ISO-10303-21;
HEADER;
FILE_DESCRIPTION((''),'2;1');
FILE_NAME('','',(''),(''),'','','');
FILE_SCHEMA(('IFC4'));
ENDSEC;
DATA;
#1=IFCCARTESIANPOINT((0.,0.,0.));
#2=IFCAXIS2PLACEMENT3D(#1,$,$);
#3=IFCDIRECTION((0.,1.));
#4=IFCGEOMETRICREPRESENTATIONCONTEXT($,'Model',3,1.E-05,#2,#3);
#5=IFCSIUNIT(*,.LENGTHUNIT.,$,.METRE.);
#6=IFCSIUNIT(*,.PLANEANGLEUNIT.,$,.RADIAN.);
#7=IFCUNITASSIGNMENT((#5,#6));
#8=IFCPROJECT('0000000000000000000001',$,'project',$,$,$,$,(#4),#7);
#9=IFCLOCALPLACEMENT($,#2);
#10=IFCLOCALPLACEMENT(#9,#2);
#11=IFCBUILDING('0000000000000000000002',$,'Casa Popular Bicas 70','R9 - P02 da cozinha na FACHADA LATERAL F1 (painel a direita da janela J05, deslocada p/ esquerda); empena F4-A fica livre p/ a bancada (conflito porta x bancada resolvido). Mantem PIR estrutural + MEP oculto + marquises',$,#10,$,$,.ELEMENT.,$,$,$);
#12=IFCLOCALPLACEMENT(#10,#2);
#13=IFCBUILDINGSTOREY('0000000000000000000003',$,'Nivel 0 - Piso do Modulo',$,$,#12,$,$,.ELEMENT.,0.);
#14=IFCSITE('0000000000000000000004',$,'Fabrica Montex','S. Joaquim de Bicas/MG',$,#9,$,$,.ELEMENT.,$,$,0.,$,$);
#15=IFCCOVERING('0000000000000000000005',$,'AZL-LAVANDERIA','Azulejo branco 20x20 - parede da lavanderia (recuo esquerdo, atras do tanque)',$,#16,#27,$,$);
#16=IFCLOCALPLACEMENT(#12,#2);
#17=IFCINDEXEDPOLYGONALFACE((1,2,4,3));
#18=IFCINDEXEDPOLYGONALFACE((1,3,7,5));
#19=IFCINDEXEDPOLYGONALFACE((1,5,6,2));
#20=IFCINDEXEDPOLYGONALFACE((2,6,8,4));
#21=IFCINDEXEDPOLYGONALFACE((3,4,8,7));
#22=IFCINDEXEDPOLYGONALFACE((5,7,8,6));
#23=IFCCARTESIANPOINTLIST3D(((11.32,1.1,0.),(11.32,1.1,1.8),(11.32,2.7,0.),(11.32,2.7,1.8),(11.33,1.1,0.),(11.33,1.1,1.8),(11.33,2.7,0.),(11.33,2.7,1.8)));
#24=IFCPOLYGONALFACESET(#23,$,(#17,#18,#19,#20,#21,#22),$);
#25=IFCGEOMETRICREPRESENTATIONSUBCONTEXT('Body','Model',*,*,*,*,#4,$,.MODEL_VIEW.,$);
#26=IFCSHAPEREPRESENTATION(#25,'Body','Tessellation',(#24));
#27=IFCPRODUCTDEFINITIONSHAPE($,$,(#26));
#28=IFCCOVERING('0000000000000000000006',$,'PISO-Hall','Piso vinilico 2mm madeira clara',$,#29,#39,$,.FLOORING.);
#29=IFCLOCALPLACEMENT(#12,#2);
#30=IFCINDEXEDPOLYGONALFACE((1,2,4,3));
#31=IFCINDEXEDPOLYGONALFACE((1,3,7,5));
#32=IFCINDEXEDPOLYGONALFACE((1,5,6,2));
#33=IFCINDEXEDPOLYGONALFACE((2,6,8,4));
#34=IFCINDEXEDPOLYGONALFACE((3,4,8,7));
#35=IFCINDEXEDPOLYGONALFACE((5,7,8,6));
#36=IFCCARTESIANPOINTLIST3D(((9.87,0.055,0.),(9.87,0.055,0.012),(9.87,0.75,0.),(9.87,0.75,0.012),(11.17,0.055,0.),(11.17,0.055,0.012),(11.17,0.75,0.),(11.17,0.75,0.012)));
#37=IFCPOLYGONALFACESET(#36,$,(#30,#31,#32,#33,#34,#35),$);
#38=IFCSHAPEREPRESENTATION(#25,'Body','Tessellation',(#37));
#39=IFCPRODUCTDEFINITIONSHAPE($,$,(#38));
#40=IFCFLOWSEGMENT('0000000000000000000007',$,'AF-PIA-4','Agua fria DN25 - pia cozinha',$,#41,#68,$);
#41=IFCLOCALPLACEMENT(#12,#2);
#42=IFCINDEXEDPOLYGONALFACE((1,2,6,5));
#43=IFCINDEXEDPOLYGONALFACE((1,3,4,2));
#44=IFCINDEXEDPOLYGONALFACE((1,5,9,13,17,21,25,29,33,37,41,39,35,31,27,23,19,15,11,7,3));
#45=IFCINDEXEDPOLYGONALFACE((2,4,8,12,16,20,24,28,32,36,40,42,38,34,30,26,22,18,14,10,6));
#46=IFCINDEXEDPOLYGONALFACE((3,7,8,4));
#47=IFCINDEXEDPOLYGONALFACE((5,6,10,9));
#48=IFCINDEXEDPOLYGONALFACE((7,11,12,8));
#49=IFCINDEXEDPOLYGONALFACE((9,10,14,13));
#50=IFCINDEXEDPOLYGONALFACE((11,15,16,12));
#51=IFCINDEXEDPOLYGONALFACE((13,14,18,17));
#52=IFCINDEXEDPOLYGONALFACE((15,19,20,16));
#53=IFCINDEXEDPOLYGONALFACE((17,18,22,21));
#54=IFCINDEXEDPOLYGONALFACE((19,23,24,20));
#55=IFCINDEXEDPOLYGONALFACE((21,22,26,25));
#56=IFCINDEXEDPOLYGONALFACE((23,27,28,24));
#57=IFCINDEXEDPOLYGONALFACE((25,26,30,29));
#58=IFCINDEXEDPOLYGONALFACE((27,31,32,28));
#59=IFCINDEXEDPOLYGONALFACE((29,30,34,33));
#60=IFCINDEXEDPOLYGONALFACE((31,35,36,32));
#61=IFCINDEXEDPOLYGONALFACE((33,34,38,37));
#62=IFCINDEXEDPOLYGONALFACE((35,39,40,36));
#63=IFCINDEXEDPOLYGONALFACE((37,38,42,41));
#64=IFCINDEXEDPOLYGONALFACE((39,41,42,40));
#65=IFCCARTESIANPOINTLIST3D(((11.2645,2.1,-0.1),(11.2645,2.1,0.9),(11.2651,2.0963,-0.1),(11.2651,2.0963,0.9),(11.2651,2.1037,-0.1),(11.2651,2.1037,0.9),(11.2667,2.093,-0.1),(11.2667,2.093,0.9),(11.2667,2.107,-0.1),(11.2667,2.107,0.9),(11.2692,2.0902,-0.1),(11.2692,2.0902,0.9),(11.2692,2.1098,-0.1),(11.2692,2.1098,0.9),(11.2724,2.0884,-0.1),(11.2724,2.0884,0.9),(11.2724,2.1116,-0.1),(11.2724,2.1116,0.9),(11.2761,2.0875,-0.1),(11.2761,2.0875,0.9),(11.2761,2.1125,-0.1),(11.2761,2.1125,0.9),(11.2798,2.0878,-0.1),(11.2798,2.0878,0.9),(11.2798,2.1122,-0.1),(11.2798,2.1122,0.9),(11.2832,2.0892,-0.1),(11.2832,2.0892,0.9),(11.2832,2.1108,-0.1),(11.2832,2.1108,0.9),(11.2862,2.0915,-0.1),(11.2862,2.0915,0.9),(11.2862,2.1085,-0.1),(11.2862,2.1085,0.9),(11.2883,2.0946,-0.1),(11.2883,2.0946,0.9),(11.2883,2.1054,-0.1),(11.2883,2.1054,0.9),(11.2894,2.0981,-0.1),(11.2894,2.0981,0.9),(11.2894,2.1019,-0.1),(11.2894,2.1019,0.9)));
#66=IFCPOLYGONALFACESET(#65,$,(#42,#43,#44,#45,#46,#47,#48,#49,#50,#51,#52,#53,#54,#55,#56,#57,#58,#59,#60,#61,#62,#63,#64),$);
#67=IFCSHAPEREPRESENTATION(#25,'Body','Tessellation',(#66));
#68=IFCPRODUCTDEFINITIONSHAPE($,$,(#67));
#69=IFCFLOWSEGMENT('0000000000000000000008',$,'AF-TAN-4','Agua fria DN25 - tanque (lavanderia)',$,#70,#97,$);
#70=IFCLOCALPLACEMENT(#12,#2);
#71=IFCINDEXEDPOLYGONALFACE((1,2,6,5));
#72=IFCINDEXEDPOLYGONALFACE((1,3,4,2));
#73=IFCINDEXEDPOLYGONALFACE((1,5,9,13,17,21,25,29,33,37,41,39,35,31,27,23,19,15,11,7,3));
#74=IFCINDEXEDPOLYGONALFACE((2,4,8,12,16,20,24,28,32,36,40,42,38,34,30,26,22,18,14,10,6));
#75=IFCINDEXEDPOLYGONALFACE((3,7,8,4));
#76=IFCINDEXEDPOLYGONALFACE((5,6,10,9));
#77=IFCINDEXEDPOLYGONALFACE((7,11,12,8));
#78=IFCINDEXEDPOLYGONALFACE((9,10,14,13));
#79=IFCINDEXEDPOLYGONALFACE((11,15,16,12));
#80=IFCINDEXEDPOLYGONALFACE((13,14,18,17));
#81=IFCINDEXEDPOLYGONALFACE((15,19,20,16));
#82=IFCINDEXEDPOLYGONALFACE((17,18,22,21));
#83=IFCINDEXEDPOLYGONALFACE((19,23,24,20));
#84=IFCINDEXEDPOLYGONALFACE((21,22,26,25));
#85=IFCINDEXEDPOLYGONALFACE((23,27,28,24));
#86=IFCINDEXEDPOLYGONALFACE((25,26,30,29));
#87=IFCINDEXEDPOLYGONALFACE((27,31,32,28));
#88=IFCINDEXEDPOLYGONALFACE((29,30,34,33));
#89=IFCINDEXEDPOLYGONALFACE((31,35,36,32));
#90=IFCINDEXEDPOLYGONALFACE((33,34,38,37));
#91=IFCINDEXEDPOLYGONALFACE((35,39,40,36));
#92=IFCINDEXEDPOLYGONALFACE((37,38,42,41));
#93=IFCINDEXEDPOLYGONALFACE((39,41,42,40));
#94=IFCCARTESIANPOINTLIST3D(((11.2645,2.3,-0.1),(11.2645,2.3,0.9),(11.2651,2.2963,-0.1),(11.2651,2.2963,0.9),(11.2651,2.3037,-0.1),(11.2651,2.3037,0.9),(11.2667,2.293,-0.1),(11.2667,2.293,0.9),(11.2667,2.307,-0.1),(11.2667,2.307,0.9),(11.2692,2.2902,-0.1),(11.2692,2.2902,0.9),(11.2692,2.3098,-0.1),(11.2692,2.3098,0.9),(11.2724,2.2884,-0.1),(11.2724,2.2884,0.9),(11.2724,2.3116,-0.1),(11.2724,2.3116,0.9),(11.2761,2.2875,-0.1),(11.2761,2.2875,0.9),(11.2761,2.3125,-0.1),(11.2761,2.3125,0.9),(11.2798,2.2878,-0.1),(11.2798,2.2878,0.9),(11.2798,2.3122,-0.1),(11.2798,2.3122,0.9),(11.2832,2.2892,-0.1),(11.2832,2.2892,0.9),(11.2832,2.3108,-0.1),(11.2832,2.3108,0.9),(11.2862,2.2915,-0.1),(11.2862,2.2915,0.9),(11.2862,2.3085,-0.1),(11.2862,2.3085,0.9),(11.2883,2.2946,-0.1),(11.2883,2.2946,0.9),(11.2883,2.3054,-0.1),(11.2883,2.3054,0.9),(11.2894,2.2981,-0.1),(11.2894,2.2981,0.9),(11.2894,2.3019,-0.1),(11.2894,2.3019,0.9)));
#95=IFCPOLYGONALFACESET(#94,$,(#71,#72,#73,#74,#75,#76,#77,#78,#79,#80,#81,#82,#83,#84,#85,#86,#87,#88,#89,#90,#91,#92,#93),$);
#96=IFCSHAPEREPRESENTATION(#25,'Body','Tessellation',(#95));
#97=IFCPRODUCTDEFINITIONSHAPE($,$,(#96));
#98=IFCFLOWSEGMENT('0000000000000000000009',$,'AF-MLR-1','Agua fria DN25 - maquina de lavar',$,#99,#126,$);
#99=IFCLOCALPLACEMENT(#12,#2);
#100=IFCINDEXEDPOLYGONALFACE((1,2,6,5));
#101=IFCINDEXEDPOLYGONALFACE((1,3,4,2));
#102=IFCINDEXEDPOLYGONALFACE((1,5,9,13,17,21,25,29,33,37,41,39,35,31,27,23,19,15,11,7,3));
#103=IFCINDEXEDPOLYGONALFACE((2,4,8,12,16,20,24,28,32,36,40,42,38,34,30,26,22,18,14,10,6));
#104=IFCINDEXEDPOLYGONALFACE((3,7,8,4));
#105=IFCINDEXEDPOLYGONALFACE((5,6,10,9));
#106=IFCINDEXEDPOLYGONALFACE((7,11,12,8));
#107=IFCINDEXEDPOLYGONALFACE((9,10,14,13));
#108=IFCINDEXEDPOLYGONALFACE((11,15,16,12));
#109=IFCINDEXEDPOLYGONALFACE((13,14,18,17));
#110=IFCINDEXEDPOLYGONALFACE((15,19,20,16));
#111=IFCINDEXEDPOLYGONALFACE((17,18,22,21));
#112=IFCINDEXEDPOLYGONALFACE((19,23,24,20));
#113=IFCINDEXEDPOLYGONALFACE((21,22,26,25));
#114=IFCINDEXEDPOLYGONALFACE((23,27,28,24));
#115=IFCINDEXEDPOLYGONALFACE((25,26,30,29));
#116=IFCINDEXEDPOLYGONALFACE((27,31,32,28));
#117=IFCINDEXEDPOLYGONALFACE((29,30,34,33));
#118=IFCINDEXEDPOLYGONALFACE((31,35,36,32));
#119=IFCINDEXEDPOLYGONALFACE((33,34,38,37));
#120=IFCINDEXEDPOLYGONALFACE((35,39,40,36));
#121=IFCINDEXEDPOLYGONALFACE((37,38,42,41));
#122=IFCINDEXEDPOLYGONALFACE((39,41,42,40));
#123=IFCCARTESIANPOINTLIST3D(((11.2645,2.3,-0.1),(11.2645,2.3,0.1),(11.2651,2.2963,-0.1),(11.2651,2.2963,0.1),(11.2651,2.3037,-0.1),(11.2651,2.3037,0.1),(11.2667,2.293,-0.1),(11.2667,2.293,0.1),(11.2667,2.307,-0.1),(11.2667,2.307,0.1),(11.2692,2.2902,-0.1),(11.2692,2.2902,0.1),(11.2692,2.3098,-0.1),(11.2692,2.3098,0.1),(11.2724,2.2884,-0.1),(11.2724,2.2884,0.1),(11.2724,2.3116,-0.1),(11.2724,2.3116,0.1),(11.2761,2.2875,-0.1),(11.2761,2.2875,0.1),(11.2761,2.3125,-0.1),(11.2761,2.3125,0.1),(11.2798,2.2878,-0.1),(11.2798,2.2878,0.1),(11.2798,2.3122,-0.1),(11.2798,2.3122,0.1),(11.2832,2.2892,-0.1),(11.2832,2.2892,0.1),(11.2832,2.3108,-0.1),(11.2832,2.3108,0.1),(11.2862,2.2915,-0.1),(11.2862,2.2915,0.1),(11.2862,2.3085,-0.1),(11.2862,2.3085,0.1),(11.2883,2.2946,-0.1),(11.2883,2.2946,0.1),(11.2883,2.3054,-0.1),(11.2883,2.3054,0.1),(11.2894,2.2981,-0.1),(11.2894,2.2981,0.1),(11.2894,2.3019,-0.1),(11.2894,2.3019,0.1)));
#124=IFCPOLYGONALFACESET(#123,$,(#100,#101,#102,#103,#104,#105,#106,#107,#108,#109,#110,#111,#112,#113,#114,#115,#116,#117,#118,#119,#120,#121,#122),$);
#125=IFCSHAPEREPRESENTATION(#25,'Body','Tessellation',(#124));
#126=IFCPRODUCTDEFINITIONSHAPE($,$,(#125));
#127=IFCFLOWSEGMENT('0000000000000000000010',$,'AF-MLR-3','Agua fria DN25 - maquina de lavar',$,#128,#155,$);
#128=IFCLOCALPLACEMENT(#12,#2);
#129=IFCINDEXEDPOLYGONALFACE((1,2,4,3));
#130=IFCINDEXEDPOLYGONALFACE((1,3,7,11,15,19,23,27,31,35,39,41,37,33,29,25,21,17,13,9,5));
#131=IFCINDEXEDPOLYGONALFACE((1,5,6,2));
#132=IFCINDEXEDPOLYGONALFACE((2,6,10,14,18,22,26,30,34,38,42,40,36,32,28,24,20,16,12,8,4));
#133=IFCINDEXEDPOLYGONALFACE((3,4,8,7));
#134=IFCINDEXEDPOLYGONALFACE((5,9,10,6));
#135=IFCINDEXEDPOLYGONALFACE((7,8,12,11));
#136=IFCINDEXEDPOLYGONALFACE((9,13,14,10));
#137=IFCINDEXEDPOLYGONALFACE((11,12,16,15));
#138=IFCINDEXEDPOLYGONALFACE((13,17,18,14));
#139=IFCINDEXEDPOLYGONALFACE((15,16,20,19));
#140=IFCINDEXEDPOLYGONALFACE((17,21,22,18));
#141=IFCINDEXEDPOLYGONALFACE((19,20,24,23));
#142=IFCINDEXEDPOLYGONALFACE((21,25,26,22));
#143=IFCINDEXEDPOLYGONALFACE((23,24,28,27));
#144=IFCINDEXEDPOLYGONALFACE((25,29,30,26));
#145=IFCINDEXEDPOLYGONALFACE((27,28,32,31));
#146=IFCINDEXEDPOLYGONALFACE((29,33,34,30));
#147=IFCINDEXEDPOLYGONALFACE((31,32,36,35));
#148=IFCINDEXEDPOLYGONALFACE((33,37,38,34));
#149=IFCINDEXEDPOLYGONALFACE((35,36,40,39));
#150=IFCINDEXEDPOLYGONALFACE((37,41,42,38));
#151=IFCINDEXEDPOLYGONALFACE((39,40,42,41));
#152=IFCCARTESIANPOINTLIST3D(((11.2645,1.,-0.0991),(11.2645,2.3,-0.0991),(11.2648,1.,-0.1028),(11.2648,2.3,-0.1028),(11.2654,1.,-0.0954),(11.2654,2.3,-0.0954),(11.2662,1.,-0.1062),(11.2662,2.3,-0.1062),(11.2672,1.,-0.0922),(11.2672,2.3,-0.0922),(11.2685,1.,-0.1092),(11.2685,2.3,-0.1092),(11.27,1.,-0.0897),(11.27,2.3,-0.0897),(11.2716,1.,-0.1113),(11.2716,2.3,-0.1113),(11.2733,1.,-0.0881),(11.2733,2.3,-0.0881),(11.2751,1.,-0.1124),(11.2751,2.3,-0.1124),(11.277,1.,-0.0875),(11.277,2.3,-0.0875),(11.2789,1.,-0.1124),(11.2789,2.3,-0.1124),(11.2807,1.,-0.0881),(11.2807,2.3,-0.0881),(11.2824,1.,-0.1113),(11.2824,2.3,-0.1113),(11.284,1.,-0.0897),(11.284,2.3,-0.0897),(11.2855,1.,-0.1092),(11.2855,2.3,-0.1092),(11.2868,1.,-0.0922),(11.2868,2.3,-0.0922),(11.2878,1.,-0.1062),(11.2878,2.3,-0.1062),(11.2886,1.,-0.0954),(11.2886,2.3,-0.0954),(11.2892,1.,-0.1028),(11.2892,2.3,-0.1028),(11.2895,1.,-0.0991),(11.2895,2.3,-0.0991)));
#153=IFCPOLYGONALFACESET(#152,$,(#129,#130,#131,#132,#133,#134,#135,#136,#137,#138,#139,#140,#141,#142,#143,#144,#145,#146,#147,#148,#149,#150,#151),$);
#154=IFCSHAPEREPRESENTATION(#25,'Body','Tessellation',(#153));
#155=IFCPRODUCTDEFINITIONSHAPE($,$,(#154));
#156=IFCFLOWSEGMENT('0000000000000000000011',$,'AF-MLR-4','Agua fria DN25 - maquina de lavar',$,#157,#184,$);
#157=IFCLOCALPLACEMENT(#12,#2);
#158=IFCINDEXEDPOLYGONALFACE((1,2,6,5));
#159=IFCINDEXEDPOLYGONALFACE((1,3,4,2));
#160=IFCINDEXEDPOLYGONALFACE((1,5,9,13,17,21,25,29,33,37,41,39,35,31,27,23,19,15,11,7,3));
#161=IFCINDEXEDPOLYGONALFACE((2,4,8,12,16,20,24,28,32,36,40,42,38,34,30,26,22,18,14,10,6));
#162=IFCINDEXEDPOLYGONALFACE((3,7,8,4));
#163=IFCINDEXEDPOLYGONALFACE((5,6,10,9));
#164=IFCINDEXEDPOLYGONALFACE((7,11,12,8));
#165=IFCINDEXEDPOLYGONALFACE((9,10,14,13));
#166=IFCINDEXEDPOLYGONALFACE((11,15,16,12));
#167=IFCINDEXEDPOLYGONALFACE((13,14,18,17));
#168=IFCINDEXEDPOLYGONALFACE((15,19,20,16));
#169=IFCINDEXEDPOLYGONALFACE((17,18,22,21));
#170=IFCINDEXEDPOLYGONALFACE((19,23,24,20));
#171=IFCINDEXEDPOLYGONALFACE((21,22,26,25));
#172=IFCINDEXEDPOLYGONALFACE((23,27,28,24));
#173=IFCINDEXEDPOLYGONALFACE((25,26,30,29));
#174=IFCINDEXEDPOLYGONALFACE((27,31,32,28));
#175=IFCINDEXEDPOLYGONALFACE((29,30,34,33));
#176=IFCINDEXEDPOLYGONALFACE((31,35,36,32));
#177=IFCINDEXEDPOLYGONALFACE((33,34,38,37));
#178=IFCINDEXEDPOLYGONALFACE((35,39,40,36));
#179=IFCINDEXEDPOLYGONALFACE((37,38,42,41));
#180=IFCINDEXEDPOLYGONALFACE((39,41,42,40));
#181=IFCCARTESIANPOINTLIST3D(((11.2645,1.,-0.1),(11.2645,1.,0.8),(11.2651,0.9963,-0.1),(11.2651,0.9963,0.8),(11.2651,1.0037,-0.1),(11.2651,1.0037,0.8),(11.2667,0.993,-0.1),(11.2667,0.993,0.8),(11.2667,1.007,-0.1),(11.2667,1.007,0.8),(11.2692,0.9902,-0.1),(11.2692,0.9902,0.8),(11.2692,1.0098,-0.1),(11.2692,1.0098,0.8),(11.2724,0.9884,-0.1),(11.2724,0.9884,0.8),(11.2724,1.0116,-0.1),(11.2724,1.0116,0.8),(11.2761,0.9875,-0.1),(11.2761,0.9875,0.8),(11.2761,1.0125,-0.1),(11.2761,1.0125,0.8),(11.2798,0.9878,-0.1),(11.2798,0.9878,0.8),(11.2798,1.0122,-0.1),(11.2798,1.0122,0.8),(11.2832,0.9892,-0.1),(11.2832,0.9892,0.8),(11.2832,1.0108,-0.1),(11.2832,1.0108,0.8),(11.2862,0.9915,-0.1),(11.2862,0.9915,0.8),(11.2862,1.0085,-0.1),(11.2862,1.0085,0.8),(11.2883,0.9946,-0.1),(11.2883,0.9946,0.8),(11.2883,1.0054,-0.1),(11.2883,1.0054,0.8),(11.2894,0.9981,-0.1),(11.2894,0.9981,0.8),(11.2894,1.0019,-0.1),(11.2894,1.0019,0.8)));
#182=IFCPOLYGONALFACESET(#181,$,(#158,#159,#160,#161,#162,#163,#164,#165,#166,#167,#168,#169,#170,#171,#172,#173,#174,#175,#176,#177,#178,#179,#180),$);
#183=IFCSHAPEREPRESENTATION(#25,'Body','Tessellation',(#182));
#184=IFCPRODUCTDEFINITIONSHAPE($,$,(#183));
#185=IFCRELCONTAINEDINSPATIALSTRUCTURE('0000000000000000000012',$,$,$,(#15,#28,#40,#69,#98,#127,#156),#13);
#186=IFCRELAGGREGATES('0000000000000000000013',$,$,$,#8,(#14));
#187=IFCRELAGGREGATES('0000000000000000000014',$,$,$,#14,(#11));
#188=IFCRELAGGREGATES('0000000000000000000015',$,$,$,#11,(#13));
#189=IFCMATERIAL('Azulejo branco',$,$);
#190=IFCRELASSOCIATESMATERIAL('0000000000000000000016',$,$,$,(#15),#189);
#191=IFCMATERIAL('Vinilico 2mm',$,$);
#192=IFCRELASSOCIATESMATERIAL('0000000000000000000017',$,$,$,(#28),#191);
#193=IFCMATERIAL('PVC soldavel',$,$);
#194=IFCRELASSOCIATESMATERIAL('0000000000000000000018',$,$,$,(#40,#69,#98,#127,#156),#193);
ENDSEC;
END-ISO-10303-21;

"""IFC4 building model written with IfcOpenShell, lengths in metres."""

from ifc_helpers import new_model, si_unit, direction, frame, frame_2d, origin, origin_2d, place, context, subcontext, project, spatial, rectangle, circle, extrude, material, element, save


model = new_model("IFC4")

# Units and contexts
model_context = context("Model", 3, precision=1e-05, world=origin(), true_north=direction((0.0, 1.0)))
body_context = subcontext(model_context, "Body", "Model", "MODEL_VIEW")
ifc_project = project(units=[si_unit("LENGTHUNIT", "METRE"), si_unit("PLANEANGLEUNIT", "RADIAN")], contexts=[model_context])

# Site, building, storey
site_placement = place(None, origin())
site = spatial("IfcSite", under=ifc_project, at=site_placement, Name="Fabrica Montex", Description="S. Joaquim de Bicas/MG", CompositionType="ELEMENT", RefElevation=0.0)
building_placement = place(site_placement, origin())
building = spatial("IfcBuilding", under=site, at=building_placement, Name="Casa Popular Bicas 70", Description="R9 - P02 da cozinha na FACHADA LATERAL F1 (painel a direita da janela J05, deslocada p/ esquerda); empena F4-A fica livre p/ a bancada (conflito porta x bancada resolvido). Mantem PIR estrutural + MEP oculto + marquises", CompositionType="ELEMENT")
storey_placement = place(building_placement, origin())
storey = spatial("IfcBuildingStorey", under=building, at=storey_placement, Name="Nivel 0 - Piso do Modulo", CompositionType="ELEMENT", Elevation=0.0)

# Coverings
ifc_material_1 = material(Name="Azulejo branco")
covering_1_placement = place(None, frame((11.325, 2.7, 0.0), z_axis=(0.0, 0.0, 1.0), x_axis=(0.0, -1.0, 0.0)))
element("IfcCovering", 1, at=covering_1_placement, inside=storey, material=ifc_material_1, Name="AZL-LAVANDERIA", Description="Azulejo branco 20x20 - parede da lavanderia (recuo esquerdo, atras do tanque)", context=body_context, shape_type="SweptSolid", body=[
    extrude(rectangle(XDim=1.6, YDim=0.01, at=frame_2d((0.8, 0.0))), origin(), (0.0, 0.0, 1.0), 1.8),
])
ifc_material_2 = material(Name="Vinilico 2mm")
covering_2_placement = place(None, frame((11.17, 0.75, 0.0), z_axis=(0.0, 0.0, 1.0), x_axis=(-1.0, 0.0, 0.0)))
element("IfcCovering", 2, at=covering_2_placement, inside=storey, material=ifc_material_2, Name="PISO-Hall", Description="Piso vinilico 2mm madeira clara", PredefinedType="FLOORING", context=body_context, shape_type="SweptSolid", body=[
    extrude(rectangle(XDim=1.3, YDim=0.695, at=frame_2d((0.65, 0.3475))), origin(), (0.0, 0.0, 1.0), 0.012),
])

# Flow segments
ifc_material_3 = material(Name="PVC soldavel")
for number, where, z_axis, x_axis, name, description in (
    (3, (11.277, 2.1, -0.1), (0.0, 0.0, 1.0), (-1.0, 0.0, 0.0), "AF-PIA-4", "Agua fria DN25 - pia cozinha"),
    (4, (11.277, 2.3, -0.1), (0.0, 0.0, 1.0), (-1.0, 0.0, 0.0), "AF-TAN-4", "Agua fria DN25 - tanque (lavanderia)"),
):
    element("IfcFlowSegment", number, at=place(None, frame(where, z_axis=z_axis, x_axis=x_axis)), inside=storey, material=ifc_material_3, Name=name, Description=description, context=body_context, shape_type="SweptSolid", body=[
        extrude(circle(Radius=0.0125, at=origin_2d()), origin(), (0.0, 0.0, 1.0), 1.0),
    ])
flow_segment_1_placement = place(None, frame((11.277, 2.3, 0.1), z_axis=(0.0, 0.0, -1.0), x_axis=(-1.0, 0.0, 0.0)))
element("IfcFlowSegment", 5, at=flow_segment_1_placement, inside=storey, material=ifc_material_3, Name="AF-MLR-1", Description="Agua fria DN25 - maquina de lavar", context=body_context, shape_type="SweptSolid", body=[
    extrude(circle(Radius=0.0125, at=origin_2d()), origin(), (0.0, 0.0, 1.0), 0.2),
])
flow_segment_2_placement = place(None, frame((11.277, 2.3, -0.1), z_axis=(0.0, -1.0, 0.0), x_axis=(0.0, 0.0, 1.0)))
element("IfcFlowSegment", 6, at=flow_segment_2_placement, inside=storey, material=ifc_material_3, Name="AF-MLR-3", Description="Agua fria DN25 - maquina de lavar", context=body_context, shape_type="SweptSolid", body=[
    extrude(circle(Radius=0.0125, at=origin_2d()), origin(), (0.0, 0.0, 1.0), 1.3),
])
flow_segment_3_placement = place(None, frame((11.277, 1.0, -0.1), z_axis=(0.0, 0.0, 1.0), x_axis=(-1.0, 0.0, 0.0)))
element("IfcFlowSegment", 7, at=flow_segment_3_placement, inside=storey, material=ifc_material_3, Name="AF-MLR-4", Description="Agua fria DN25 - maquina de lavar", context=body_context, shape_type="SweptSolid", body=[
    extrude(circle(Radius=0.0125, at=origin_2d()), origin(), (0.0, 0.0, 1.0), 0.9),
])

save(model, "model.ifc")
